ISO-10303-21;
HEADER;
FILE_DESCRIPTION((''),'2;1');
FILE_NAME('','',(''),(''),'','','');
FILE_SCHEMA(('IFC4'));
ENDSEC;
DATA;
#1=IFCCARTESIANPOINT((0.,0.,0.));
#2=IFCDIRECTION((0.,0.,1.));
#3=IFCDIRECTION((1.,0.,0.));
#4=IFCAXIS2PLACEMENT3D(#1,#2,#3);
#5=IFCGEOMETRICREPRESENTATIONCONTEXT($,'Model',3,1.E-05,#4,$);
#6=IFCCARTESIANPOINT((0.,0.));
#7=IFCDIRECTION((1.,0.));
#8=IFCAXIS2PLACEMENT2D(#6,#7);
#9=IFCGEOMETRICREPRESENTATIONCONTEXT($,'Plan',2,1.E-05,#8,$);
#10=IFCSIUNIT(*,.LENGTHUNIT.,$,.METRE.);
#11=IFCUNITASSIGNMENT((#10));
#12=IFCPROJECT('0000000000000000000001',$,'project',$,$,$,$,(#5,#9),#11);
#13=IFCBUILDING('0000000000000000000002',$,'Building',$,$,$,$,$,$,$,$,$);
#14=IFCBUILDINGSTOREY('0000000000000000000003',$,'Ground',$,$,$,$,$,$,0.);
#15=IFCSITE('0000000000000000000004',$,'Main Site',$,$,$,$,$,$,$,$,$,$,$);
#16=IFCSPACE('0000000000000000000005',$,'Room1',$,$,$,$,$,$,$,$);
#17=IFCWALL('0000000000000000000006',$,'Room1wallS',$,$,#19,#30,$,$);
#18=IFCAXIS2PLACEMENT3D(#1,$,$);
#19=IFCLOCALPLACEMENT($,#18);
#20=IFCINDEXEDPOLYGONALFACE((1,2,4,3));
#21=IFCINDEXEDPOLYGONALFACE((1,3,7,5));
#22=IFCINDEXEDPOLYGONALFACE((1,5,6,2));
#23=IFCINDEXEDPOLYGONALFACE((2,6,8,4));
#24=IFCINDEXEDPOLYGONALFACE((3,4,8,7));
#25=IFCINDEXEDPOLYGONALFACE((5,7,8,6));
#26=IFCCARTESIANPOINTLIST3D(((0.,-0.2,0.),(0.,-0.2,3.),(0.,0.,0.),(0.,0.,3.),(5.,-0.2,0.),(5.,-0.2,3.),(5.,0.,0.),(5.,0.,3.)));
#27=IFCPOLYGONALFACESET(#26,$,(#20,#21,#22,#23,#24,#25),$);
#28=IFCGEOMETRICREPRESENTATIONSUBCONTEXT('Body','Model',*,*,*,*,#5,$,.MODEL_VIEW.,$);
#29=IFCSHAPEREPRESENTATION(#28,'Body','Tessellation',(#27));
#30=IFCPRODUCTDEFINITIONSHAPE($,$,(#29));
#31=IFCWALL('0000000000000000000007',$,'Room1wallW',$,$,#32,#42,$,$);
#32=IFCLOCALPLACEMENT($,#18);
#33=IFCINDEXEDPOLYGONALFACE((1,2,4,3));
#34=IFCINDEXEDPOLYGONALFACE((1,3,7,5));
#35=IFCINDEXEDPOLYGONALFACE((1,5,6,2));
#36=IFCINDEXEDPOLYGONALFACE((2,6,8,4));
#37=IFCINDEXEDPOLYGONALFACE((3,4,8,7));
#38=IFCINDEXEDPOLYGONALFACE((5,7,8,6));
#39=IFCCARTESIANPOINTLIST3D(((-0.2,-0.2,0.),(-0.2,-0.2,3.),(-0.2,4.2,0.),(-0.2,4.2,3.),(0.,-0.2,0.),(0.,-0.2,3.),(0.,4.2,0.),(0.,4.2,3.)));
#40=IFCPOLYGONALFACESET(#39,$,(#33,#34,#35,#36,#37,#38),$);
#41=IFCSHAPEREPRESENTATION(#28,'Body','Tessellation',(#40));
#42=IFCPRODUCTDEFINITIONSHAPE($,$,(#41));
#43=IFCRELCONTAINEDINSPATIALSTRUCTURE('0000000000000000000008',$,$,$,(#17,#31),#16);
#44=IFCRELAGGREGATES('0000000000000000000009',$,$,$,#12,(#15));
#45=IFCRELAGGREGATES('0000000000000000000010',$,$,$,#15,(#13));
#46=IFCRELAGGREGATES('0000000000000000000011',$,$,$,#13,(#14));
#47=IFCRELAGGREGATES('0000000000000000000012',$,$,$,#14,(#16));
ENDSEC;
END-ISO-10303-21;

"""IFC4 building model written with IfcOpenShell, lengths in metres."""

from ifc_helpers import new_model, si_unit, frame, origin_with_axes, origin_2d_with_axis, place, context, subcontext, project, spatial, indexed_curve, outline, extrude, element, save


model = new_model("IFC4")

# Units and contexts
model_context = context("Model", 3, precision=1e-05, world=origin_with_axes())
plan_context = context("Plan", 2, precision=1e-05, world=origin_2d_with_axis())
body_context = subcontext(model_context, "Body", "Model", "MODEL_VIEW")
ifc_project = project(units=[si_unit("LENGTHUNIT", "METRE")], contexts=[model_context, plan_context])

# Site, building, storey, space
site = spatial("IfcSite", under=ifc_project, Name="Main Site")
building = spatial("IfcBuilding", under=site, Name="Building")
storey = spatial("IfcBuildingStorey", under=building, Name="Ground", Elevation=0.0)
space_1 = spatial("IfcSpace", under=storey, Name="Room1")

# Walls
wall_1_placement = place(None, frame((0.0, -0.2, 0.0), z_axis=(0.0, 0.0, 1.0), x_axis=(1.0, 0.0, 0.0)))
element("IfcWall", 1, at=wall_1_placement, inside=space_1, Name="Room1wallS", context=body_context, shape_type="SweptSolid", body=[
    extrude(outline(indexed_curve([(0.0, 0.0), (0.0, 0.2), (5.0, 0.2), (5.0, 0.0), (0.0, 0.0)], self_intersect=False)), origin_with_axes(), (0.0, 0.0, 1.0), 3.0),
])
wall_2_placement = place(None, frame((0.0, -0.2, 0.0), z_axis=(0.0, 0.0, 1.0), x_axis=(0.0, 1.0, 0.0)))
element("IfcWall", 2, at=wall_2_placement, inside=space_1, Name="Room1wallW", context=body_context, shape_type="SweptSolid", body=[
    extrude(outline(indexed_curve([(0.0, 0.0), (0.0, 0.2), (4.4, 0.2), (4.4, 0.0), (0.0, 0.0)], self_intersect=False)), origin_with_axes(), (0.0, 0.0, 1.0), 3.0),
])

save(model, "model.ifc")
